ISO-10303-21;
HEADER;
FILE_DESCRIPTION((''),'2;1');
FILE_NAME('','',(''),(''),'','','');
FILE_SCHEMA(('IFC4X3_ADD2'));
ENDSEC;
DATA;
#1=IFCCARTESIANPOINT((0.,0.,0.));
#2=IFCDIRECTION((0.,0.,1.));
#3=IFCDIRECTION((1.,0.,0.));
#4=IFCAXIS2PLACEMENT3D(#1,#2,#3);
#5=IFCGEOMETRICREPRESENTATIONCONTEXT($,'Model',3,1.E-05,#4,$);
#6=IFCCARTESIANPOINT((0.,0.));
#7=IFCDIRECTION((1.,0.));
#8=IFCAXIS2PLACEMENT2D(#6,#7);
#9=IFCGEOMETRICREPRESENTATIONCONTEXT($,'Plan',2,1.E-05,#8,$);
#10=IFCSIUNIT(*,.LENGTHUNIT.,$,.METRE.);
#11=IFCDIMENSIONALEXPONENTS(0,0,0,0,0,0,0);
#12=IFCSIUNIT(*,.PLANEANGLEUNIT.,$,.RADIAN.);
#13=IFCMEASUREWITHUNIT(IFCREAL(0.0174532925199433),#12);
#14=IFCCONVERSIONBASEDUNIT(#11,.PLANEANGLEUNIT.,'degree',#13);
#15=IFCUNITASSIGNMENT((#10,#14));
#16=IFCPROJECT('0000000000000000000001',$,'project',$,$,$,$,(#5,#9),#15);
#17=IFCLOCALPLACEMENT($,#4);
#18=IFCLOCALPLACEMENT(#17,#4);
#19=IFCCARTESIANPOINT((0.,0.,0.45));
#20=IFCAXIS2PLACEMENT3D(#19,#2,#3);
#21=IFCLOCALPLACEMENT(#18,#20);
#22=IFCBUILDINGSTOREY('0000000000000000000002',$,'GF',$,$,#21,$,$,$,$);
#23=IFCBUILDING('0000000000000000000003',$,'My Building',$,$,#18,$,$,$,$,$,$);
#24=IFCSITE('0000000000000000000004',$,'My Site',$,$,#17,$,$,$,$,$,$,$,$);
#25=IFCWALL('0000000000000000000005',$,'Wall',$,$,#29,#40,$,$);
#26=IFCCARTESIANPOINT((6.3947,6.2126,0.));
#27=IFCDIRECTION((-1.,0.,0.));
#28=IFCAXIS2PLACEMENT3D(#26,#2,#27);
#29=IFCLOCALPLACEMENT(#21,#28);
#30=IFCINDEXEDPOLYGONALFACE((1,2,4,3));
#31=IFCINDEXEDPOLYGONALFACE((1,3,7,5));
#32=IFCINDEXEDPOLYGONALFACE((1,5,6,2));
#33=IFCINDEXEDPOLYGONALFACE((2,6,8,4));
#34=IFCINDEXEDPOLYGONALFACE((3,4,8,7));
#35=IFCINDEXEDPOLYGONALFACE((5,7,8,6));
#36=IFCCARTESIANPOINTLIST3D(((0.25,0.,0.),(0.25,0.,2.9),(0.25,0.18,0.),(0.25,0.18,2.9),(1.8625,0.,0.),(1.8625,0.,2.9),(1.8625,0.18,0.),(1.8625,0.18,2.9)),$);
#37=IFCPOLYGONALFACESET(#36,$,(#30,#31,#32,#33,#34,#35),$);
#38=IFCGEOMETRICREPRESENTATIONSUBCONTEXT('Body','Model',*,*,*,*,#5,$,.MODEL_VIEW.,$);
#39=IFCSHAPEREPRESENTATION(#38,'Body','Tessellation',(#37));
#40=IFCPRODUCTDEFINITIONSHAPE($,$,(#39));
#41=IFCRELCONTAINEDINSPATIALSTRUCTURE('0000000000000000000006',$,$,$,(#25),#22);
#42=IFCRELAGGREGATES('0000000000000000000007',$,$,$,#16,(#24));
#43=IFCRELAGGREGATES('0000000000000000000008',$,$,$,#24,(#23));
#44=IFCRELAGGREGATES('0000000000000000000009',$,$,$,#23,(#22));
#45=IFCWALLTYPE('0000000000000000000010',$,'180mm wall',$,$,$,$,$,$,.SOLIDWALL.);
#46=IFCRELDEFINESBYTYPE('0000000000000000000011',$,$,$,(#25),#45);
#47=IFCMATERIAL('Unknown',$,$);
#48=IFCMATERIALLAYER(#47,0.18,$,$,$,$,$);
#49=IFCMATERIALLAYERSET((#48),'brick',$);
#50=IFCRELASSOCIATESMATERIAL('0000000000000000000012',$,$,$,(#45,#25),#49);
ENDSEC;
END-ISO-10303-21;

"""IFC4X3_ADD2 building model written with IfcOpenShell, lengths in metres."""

from ifc_helpers import new_model, entity, si_unit, converted_unit, frame, origin_with_axes, origin_2d_with_axis, place, context, subcontext, project, spatial, line, indexed_curve, outline, extrude, material, layer, layer_set, layer_usage, type_object, element, save


model = new_model("IFC4X3_ADD2")

# Units and contexts
model_context = context("Model", 3, precision=1e-05, world=origin_with_axes())
plan_context = context("Plan", 2, precision=1e-05, world=origin_2d_with_axis())
body_context_1 = subcontext(model_context, "Body", "Model", "MODEL_VIEW")
ifc_project = project(units=[si_unit("LENGTHUNIT", "METRE"), converted_unit("PLANEANGLEUNIT", "degree", entity("IfcReal", 0.0174532925199433), si_unit("PLANEANGLEUNIT", "RADIAN"), dimensions=[0, 0, 0, 0, 0, 0, 0])], contexts=[model_context, plan_context])

# Site, building, storey
site_placement = place(None, origin_with_axes())
site = spatial("IfcSite", under=ifc_project, at=site_placement, Name="My Site")
building_placement = place(site_placement, origin_with_axes())
building = spatial("IfcBuilding", under=site, at=building_placement, Name="My Building")
storey_placement = place(building_placement, frame((0.0, 0.0, 0.45), z_axis=(0.0, 0.0, 1.0), x_axis=(1.0, 0.0, 0.0)))
storey = spatial("IfcBuildingStorey", under=building, at=storey_placement, Name="GF")

# Shared definitions
ifc_material_1 = material(Name="Unknown")

# Shared definitions
ifc_layer_1 = layer(ifc_material_1, 0.18)
ifc_layer_set_1 = layer_set([ifc_layer_1], Name="brick")
wall_type_1 = type_object("IfcWallType", Name="180mm wall", PredefinedType="SOLIDWALL", material=ifc_layer_set_1)

# Wall
ifc_layer_usage_1 = layer_usage(ifc_layer_set_1, "AXIS2", "POSITIVE", 0.0)
wall_1_placement = place(storey_placement, frame((6.3947, 6.2126, 0.0), z_axis=(0.0, 0.0, 1.0), x_axis=(-1.0, 0.0, 0.0)))
element("IfcWall", 1, at=wall_1_placement, inside=storey, type_object=wall_type_1, material=ifc_layer_usage_1, Name="Wall", context=body_context_1, shape_type="SweptSolid", body=[
    extrude(outline(indexed_curve([(0.25, 0.0), (0.25, 0.18), (1.8625, 0.18), (1.8625, 0.0)], segments=[line(1, 2, 3, 4, 1)])), origin_with_axes(), (0.0, 0.0, 1.0), 2.9),
])

save(model, "model.ifc")
